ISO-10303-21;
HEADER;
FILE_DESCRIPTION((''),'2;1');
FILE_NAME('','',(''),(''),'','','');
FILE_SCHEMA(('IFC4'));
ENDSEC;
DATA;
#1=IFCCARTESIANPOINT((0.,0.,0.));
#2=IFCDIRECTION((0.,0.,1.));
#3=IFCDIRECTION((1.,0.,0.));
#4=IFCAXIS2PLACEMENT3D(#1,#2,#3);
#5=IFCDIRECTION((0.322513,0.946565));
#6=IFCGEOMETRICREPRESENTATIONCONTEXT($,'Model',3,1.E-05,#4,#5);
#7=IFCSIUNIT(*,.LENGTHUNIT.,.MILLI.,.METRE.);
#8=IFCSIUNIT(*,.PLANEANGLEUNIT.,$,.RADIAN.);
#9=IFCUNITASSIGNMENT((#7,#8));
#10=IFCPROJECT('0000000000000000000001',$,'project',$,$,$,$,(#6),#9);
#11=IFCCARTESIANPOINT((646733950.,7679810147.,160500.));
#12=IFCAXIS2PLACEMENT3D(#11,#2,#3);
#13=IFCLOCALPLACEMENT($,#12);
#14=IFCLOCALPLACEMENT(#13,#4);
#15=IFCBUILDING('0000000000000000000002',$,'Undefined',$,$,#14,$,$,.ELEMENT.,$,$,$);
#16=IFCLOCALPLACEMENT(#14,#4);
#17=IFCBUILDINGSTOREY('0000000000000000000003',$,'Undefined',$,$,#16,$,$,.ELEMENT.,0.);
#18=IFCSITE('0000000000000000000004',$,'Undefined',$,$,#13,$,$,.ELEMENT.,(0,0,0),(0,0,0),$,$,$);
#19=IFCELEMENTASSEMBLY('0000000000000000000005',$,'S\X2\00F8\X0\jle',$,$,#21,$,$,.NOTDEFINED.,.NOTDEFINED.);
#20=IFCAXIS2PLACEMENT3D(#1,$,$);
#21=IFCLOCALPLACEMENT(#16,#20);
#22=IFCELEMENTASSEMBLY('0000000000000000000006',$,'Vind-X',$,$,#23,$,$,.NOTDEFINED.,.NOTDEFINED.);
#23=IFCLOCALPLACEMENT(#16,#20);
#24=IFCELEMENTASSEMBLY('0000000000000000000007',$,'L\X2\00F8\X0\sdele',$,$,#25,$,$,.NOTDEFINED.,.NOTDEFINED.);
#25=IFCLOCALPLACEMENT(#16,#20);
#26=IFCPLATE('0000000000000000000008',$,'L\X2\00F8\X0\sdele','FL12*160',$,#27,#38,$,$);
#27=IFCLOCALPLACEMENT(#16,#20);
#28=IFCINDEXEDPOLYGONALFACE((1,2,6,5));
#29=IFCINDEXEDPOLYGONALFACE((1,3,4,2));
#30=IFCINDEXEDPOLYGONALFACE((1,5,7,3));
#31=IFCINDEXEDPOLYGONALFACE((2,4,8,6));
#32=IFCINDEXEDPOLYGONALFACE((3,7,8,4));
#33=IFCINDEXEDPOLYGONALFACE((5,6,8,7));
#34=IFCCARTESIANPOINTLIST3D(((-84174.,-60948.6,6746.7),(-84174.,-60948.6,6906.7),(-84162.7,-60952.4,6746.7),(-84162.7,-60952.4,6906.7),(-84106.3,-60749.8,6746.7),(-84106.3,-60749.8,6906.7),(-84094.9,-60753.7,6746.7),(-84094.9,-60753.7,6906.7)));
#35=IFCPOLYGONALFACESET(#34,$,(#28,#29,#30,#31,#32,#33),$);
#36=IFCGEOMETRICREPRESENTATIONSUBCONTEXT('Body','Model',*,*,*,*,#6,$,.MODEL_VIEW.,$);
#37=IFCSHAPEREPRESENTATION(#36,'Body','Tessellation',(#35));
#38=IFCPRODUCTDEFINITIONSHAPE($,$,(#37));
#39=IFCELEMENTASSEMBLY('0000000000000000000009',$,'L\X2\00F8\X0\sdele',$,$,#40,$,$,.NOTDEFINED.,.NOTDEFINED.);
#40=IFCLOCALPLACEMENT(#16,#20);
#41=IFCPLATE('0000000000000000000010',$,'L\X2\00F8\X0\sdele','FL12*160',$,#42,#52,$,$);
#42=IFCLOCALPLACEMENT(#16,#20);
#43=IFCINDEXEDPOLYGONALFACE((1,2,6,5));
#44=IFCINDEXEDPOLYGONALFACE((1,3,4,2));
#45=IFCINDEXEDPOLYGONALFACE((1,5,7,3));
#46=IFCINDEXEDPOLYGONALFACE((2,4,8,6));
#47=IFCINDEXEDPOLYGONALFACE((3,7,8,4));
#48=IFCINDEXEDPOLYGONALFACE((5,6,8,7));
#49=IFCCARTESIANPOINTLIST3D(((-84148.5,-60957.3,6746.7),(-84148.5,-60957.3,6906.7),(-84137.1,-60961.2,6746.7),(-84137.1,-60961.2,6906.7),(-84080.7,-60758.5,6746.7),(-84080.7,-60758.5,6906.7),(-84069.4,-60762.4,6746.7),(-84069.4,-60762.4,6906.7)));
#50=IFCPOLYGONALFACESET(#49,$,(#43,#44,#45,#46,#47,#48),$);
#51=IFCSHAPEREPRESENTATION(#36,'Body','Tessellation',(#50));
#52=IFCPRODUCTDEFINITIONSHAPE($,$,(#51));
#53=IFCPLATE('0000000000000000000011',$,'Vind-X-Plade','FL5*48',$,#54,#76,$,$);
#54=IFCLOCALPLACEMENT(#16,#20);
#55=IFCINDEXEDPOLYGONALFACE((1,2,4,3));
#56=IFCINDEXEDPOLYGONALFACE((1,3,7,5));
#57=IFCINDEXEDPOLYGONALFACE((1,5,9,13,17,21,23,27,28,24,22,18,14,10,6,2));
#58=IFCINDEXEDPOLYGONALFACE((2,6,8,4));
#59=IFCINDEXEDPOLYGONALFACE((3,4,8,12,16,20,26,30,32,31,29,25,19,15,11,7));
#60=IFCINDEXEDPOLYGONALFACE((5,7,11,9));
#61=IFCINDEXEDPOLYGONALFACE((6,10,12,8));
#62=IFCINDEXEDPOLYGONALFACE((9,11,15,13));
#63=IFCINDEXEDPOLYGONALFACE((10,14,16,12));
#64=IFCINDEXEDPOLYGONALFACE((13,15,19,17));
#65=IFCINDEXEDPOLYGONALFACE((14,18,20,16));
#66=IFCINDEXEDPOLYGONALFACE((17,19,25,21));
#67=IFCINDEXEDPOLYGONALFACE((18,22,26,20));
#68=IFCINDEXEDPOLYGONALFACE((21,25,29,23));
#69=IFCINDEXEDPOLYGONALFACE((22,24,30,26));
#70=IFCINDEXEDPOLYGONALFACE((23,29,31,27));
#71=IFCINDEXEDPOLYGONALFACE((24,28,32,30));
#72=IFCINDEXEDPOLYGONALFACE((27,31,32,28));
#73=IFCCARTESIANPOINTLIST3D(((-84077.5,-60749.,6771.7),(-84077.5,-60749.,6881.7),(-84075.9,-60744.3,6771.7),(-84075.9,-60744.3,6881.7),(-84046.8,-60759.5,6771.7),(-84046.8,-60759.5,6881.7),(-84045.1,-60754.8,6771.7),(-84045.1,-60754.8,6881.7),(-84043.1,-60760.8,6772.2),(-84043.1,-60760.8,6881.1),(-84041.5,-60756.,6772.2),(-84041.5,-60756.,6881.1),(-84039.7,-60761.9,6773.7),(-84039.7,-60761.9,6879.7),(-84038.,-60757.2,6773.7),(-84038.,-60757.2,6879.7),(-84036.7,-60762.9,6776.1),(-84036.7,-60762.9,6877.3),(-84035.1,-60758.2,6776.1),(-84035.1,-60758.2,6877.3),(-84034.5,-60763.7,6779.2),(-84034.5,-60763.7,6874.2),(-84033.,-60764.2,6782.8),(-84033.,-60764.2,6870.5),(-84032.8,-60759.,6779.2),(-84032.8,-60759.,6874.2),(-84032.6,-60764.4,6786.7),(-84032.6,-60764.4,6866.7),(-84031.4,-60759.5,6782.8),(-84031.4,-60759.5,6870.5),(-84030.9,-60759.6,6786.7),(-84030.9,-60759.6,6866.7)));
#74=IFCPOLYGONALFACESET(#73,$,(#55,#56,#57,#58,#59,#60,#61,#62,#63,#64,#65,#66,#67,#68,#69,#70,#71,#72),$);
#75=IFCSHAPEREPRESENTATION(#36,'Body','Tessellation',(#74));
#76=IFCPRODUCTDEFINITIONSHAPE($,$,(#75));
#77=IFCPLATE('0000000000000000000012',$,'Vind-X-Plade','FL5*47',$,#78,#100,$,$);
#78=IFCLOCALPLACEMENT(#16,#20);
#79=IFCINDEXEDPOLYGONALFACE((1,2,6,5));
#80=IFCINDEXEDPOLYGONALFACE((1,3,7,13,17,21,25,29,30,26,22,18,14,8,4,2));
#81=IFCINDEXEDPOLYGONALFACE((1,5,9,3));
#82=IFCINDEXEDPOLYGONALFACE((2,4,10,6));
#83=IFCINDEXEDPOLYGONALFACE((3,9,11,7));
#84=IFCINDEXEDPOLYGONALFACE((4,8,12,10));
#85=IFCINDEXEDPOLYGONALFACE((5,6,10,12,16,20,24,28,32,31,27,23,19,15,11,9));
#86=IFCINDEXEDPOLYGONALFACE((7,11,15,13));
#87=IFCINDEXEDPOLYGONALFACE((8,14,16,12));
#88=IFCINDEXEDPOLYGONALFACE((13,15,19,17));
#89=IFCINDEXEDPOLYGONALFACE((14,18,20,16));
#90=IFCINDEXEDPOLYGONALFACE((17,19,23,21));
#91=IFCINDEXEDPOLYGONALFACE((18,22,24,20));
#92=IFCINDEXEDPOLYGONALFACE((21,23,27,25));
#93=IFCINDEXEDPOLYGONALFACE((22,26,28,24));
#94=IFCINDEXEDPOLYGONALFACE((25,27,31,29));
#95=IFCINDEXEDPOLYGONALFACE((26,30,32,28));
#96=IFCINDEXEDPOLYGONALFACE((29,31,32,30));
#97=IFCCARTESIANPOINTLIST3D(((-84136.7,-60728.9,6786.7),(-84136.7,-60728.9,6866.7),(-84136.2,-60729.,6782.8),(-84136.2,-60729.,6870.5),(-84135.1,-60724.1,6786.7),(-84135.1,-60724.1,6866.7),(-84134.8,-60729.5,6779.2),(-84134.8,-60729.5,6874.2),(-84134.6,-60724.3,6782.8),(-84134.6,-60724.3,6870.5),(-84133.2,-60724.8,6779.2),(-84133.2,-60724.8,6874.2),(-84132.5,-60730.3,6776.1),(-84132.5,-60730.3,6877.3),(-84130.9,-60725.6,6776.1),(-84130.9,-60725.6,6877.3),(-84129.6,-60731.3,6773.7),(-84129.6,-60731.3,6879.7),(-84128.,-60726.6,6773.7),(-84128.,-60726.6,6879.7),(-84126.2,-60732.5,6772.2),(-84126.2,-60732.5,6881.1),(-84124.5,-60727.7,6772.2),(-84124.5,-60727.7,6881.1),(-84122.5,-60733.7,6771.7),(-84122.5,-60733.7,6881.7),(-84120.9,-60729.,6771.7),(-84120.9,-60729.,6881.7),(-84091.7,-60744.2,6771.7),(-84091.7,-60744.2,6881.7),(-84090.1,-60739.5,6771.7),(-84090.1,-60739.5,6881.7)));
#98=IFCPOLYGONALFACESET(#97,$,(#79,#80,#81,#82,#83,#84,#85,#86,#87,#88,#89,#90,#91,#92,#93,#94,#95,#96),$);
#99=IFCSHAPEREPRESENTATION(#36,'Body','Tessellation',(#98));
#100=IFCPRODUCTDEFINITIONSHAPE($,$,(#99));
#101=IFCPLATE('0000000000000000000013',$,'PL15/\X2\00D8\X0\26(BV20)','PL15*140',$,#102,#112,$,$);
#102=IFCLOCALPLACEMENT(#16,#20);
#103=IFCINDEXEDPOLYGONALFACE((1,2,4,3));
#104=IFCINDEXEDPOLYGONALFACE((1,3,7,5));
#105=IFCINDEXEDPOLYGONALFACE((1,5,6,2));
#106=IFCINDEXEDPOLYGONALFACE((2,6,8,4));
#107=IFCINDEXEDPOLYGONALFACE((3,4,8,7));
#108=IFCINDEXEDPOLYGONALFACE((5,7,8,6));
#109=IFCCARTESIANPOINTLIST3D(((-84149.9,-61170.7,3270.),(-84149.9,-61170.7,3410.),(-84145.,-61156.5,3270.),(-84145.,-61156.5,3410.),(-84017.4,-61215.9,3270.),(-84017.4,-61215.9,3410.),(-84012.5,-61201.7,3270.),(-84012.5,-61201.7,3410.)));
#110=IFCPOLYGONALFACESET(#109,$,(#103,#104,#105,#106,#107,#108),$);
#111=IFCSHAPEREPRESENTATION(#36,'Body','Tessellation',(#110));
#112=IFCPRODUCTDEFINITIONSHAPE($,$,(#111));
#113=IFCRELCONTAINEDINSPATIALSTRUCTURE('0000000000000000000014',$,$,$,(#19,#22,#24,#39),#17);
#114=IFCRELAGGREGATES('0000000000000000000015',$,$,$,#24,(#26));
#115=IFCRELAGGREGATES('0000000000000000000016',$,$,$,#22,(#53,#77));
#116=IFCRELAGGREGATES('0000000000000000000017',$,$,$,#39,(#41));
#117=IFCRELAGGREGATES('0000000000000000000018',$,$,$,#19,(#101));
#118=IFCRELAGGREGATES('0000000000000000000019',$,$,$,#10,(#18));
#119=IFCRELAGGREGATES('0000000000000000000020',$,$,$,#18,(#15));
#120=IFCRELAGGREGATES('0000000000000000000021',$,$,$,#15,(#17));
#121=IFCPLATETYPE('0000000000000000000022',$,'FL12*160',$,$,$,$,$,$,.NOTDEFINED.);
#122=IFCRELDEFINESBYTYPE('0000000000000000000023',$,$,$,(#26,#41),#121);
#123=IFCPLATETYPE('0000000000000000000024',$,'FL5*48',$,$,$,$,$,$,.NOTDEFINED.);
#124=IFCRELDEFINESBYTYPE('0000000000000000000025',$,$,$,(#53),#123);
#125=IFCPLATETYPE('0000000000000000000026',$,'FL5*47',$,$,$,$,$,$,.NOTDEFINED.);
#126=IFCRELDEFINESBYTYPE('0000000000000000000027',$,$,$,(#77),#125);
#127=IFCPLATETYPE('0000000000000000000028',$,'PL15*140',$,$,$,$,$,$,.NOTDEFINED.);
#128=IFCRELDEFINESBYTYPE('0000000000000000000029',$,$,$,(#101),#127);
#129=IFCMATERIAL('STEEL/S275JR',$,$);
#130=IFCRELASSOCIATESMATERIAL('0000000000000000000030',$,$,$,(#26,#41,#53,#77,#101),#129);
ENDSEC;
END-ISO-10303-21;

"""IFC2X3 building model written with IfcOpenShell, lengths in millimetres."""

from ifc_helpers import new_model, si_unit, direction, frame, frame_2d, origin_with_axes, place, context, subcontext, project, spatial, polyline, circle_curve, parameter, trimmed, segment, composite_curve, outline, extrude, material, type_object, element, aggregate, save


model = new_model("IFC2X3")

# Units and contexts
model_context = context("Model", 3, precision=1e-05, world=origin_with_axes(), true_north=direction((0.322513, 0.946565)))
body_context = subcontext(model_context, "Body", "Model", "MODEL_VIEW")
ifc_project = project(units=[si_unit("LENGTHUNIT", "METRE", prefix="MILLI"), si_unit("PLANEANGLEUNIT", "RADIAN")], contexts=[model_context])

# Site, building, storey
site_placement = place(None, frame((646733950.0, 7679810147.0, 160500.0), z_axis=(0.0, 0.0, 1.0), x_axis=(1.0, 0.0, 0.0)))
site = spatial("IfcSite", under=ifc_project, at=site_placement, Name="Undefined", CompositionType="ELEMENT", RefLatitude=(0, 0, 0), RefLongitude=(0, 0, 0))
building_placement = place(site_placement, origin_with_axes())
building = spatial("IfcBuilding", under=site, at=building_placement, Name="Undefined", CompositionType="ELEMENT")
storey_placement = place(building_placement, origin_with_axes())
storey = spatial("IfcBuildingStorey", under=building, at=storey_placement, Name="Undefined", CompositionType="ELEMENT", Elevation=0.0)

# Element assembly
assembly_1_placement = place(storey_placement, origin_with_axes())
assembly_1 = element("IfcElementAssembly", 1, at=assembly_1_placement, inside=storey, Name="Søjle", AssemblyPlace="NOTDEFINED", PredefinedType="NOTDEFINED")

# Element assembly
assembly_2_placement = place(storey_placement, origin_with_axes())
assembly_2 = element("IfcElementAssembly", 2, at=assembly_2_placement, inside=storey, Name="Vind-X", AssemblyPlace="NOTDEFINED", PredefinedType="NOTDEFINED")
ifc_material_1 = material(Name="STEEL/S275JR")

# Element assemblies, plates
assembly_3_placement = place(storey_placement, origin_with_axes())
assembly_3 = element("IfcElementAssembly", 3, at=assembly_3_placement, inside=storey, Name="Løsdele", AssemblyPlace="NOTDEFINED", PredefinedType="NOTDEFINED")
plate_type_1 = type_object("IfcPlateType", Name="FL12*160", PredefinedType="NOTDEFINED")
plate_1_placement = place(assembly_3_placement, frame((-84168.4, -60950.5, 6826.7), z_axis=(-0.946565, 0.322513, 0.0), x_axis=(0.322513, 0.946565, 0.0)))
plate_1 = element("IfcPlate", 4, at=plate_1_placement, type_object=plate_type_1, material=ifc_material_1, Name="Løsdele", Description="FL12*160", context=body_context, shape_type="SweptSolid", body=[
    extrude(outline(polyline([(0.0, -80.0), (0.0, 80.0), (210.0, 80.0), (210.0, -80.0), (0.0, -80.0)])), frame((0.0, 0.0, -6.0), z_axis=(0.0, 0.0, 1.0), x_axis=(1.0, 0.0, 0.0)), (0.0, 0.0, 1.0), 12.0),
])
aggregate(assembly_3, [plate_1])
assembly_4_placement = place(storey_placement, origin_with_axes())
assembly_4 = element("IfcElementAssembly", 5, at=assembly_4_placement, inside=storey, Name="Løsdele", AssemblyPlace="NOTDEFINED", PredefinedType="NOTDEFINED")
plate_2_placement = place(assembly_4_placement, frame((-84142.8, -60959.2, 6826.7), z_axis=(-0.946565, 0.322513, 0.0), x_axis=(0.322513, 0.946565, 0.0)))
plate_2 = element("IfcPlate", 6, at=plate_2_placement, type_object=plate_type_1, material=ifc_material_1, Name="Løsdele", Description="FL12*160", context=body_context, shape_type="SweptSolid", body=[
    extrude(outline(polyline([(0.0, -80.0), (0.0, 80.0), (210.0, 80.0), (210.0, -80.0), (0.0, -80.0)])), frame((0.0, 0.0, -6.0), z_axis=(0.0, 0.0, 1.0), x_axis=(1.0, 0.0, 0.0)), (0.0, 0.0, 1.0), 12.0),
])

# Plates
plate_type_2 = type_object("IfcPlateType", Name="FL5*48", PredefinedType="NOTDEFINED")
plate_3_placement = place(assembly_2_placement, frame((-84031.8, -60762.0, 6771.7), z_axis=(0.322513, 0.946565, 0.0), x_axis=(-0.946565, 0.322513, 0.0)))
plate_3 = element("IfcPlate", 7, at=plate_3_placement, type_object=plate_type_2, material=ifc_material_1, Name="Vind-X-Plade", Description="FL5*48", context=body_context, shape_type="SweptSolid", body=[
    extrude(outline(composite_curve([segment(trimmed(circle_curve(frame_2d((15.0, 15.0), x_axis=(-1.0, 0.0)), 15.0), [parameter(0.0)], [parameter(1.570796)], True, "PARAMETER"), True, "CONTINUOUS"), segment(polyline([(15.0, 0.0), (47.5, 0.0), (47.5, 110.0), (15.0, 110.0)]), True, "CONTINUOUS"), segment(trimmed(circle_curve(frame_2d((15.0, 95.0), x_axis=(0.0, 1.0)), 15.0), [parameter(0.0)], [parameter(1.570796)], True, "PARAMETER"), True, "CONTINUOUS"), segment(polyline([(0.0, 95.0), (0.0, 15.0)]), True, "CONTINUOUS")], self_intersect=True)), frame((0.0, 0.0, -2.5), z_axis=(0.0, 0.0, 1.0), x_axis=(1.0, 0.0, 0.0)), (0.0, 0.0, 1.0), 5.0),
])
plate_type_3 = type_object("IfcPlateType", Name="FL5*47", PredefinedType="NOTDEFINED")
plate_4_placement = place(assembly_2_placement, frame((-84090.9, -60741.8, 6771.7), z_axis=(0.322513, 0.946565, 0.0), x_axis=(-0.946565, 0.322513, 0.0)))
plate_4 = element("IfcPlate", 8, at=plate_4_placement, type_object=plate_type_3, material=ifc_material_1, Name="Vind-X-Plade", Description="FL5*47", context=body_context, shape_type="SweptSolid", body=[
    extrude(outline(composite_curve([segment(polyline([(0.0, 0.0), (32.5, 0.0)]), True, "CONTINUOUS"), segment(trimmed(circle_curve(frame_2d((32.5, 15.0), x_axis=(0.0, -1.0)), 15.0), [parameter(0.0)], [parameter(1.570796)], True, "PARAMETER"), True, "CONTINUOUS"), segment(polyline([(47.5, 15.0), (47.5, 95.0)]), True, "CONTINUOUS"), segment(trimmed(circle_curve(frame_2d((32.5, 95.0), x_axis=(1.0, 0.0)), 15.0), [parameter(0.0)], [parameter(1.570796)], True, "PARAMETER"), True, "CONTINUOUS"), segment(polyline([(32.5, 110.0), (0.0, 110.0), (0.0, 0.0)]), True, "CONTINUOUS")], self_intersect=True)), frame((0.0, 0.0, -2.5), z_axis=(0.0, 0.0, 1.0), x_axis=(1.0, 0.0, 0.0)), (0.0, 0.0, 1.0), 5.0),
])
aggregate(assembly_2, [plate_3, plate_4])
plate_type_4 = type_object("IfcPlateType", Name="PL15*140", PredefinedType="NOTDEFINED")
plate_5_placement = place(assembly_1_placement, frame((-84147.5, -61163.6, 3270.0), z_axis=(-0.322513, -0.946565, 0.0), x_axis=(0.946565, -0.322513, 0.0)))
plate_5 = element("IfcPlate", 9, at=plate_5_placement, type_object=plate_type_4, material=ifc_material_1, Name="PL15/Ø26(BV20)", Description="PL15*140", context=body_context, shape_type="SweptSolid", body=[
    extrude(outline(polyline([(0.0, 0.0), (140.0, 0.0), (140.0, 140.0), (0.0, 140.0), (0.0, 0.0)])), frame((0.0, 0.0, -7.5), z_axis=(0.0, 0.0, 1.0), x_axis=(1.0, 0.0, 0.0)), (0.0, 0.0, 1.0), 15.0),
])

aggregate(assembly_4, [plate_2])
aggregate(assembly_1, [plate_5])

save(model, "model.ifc")
